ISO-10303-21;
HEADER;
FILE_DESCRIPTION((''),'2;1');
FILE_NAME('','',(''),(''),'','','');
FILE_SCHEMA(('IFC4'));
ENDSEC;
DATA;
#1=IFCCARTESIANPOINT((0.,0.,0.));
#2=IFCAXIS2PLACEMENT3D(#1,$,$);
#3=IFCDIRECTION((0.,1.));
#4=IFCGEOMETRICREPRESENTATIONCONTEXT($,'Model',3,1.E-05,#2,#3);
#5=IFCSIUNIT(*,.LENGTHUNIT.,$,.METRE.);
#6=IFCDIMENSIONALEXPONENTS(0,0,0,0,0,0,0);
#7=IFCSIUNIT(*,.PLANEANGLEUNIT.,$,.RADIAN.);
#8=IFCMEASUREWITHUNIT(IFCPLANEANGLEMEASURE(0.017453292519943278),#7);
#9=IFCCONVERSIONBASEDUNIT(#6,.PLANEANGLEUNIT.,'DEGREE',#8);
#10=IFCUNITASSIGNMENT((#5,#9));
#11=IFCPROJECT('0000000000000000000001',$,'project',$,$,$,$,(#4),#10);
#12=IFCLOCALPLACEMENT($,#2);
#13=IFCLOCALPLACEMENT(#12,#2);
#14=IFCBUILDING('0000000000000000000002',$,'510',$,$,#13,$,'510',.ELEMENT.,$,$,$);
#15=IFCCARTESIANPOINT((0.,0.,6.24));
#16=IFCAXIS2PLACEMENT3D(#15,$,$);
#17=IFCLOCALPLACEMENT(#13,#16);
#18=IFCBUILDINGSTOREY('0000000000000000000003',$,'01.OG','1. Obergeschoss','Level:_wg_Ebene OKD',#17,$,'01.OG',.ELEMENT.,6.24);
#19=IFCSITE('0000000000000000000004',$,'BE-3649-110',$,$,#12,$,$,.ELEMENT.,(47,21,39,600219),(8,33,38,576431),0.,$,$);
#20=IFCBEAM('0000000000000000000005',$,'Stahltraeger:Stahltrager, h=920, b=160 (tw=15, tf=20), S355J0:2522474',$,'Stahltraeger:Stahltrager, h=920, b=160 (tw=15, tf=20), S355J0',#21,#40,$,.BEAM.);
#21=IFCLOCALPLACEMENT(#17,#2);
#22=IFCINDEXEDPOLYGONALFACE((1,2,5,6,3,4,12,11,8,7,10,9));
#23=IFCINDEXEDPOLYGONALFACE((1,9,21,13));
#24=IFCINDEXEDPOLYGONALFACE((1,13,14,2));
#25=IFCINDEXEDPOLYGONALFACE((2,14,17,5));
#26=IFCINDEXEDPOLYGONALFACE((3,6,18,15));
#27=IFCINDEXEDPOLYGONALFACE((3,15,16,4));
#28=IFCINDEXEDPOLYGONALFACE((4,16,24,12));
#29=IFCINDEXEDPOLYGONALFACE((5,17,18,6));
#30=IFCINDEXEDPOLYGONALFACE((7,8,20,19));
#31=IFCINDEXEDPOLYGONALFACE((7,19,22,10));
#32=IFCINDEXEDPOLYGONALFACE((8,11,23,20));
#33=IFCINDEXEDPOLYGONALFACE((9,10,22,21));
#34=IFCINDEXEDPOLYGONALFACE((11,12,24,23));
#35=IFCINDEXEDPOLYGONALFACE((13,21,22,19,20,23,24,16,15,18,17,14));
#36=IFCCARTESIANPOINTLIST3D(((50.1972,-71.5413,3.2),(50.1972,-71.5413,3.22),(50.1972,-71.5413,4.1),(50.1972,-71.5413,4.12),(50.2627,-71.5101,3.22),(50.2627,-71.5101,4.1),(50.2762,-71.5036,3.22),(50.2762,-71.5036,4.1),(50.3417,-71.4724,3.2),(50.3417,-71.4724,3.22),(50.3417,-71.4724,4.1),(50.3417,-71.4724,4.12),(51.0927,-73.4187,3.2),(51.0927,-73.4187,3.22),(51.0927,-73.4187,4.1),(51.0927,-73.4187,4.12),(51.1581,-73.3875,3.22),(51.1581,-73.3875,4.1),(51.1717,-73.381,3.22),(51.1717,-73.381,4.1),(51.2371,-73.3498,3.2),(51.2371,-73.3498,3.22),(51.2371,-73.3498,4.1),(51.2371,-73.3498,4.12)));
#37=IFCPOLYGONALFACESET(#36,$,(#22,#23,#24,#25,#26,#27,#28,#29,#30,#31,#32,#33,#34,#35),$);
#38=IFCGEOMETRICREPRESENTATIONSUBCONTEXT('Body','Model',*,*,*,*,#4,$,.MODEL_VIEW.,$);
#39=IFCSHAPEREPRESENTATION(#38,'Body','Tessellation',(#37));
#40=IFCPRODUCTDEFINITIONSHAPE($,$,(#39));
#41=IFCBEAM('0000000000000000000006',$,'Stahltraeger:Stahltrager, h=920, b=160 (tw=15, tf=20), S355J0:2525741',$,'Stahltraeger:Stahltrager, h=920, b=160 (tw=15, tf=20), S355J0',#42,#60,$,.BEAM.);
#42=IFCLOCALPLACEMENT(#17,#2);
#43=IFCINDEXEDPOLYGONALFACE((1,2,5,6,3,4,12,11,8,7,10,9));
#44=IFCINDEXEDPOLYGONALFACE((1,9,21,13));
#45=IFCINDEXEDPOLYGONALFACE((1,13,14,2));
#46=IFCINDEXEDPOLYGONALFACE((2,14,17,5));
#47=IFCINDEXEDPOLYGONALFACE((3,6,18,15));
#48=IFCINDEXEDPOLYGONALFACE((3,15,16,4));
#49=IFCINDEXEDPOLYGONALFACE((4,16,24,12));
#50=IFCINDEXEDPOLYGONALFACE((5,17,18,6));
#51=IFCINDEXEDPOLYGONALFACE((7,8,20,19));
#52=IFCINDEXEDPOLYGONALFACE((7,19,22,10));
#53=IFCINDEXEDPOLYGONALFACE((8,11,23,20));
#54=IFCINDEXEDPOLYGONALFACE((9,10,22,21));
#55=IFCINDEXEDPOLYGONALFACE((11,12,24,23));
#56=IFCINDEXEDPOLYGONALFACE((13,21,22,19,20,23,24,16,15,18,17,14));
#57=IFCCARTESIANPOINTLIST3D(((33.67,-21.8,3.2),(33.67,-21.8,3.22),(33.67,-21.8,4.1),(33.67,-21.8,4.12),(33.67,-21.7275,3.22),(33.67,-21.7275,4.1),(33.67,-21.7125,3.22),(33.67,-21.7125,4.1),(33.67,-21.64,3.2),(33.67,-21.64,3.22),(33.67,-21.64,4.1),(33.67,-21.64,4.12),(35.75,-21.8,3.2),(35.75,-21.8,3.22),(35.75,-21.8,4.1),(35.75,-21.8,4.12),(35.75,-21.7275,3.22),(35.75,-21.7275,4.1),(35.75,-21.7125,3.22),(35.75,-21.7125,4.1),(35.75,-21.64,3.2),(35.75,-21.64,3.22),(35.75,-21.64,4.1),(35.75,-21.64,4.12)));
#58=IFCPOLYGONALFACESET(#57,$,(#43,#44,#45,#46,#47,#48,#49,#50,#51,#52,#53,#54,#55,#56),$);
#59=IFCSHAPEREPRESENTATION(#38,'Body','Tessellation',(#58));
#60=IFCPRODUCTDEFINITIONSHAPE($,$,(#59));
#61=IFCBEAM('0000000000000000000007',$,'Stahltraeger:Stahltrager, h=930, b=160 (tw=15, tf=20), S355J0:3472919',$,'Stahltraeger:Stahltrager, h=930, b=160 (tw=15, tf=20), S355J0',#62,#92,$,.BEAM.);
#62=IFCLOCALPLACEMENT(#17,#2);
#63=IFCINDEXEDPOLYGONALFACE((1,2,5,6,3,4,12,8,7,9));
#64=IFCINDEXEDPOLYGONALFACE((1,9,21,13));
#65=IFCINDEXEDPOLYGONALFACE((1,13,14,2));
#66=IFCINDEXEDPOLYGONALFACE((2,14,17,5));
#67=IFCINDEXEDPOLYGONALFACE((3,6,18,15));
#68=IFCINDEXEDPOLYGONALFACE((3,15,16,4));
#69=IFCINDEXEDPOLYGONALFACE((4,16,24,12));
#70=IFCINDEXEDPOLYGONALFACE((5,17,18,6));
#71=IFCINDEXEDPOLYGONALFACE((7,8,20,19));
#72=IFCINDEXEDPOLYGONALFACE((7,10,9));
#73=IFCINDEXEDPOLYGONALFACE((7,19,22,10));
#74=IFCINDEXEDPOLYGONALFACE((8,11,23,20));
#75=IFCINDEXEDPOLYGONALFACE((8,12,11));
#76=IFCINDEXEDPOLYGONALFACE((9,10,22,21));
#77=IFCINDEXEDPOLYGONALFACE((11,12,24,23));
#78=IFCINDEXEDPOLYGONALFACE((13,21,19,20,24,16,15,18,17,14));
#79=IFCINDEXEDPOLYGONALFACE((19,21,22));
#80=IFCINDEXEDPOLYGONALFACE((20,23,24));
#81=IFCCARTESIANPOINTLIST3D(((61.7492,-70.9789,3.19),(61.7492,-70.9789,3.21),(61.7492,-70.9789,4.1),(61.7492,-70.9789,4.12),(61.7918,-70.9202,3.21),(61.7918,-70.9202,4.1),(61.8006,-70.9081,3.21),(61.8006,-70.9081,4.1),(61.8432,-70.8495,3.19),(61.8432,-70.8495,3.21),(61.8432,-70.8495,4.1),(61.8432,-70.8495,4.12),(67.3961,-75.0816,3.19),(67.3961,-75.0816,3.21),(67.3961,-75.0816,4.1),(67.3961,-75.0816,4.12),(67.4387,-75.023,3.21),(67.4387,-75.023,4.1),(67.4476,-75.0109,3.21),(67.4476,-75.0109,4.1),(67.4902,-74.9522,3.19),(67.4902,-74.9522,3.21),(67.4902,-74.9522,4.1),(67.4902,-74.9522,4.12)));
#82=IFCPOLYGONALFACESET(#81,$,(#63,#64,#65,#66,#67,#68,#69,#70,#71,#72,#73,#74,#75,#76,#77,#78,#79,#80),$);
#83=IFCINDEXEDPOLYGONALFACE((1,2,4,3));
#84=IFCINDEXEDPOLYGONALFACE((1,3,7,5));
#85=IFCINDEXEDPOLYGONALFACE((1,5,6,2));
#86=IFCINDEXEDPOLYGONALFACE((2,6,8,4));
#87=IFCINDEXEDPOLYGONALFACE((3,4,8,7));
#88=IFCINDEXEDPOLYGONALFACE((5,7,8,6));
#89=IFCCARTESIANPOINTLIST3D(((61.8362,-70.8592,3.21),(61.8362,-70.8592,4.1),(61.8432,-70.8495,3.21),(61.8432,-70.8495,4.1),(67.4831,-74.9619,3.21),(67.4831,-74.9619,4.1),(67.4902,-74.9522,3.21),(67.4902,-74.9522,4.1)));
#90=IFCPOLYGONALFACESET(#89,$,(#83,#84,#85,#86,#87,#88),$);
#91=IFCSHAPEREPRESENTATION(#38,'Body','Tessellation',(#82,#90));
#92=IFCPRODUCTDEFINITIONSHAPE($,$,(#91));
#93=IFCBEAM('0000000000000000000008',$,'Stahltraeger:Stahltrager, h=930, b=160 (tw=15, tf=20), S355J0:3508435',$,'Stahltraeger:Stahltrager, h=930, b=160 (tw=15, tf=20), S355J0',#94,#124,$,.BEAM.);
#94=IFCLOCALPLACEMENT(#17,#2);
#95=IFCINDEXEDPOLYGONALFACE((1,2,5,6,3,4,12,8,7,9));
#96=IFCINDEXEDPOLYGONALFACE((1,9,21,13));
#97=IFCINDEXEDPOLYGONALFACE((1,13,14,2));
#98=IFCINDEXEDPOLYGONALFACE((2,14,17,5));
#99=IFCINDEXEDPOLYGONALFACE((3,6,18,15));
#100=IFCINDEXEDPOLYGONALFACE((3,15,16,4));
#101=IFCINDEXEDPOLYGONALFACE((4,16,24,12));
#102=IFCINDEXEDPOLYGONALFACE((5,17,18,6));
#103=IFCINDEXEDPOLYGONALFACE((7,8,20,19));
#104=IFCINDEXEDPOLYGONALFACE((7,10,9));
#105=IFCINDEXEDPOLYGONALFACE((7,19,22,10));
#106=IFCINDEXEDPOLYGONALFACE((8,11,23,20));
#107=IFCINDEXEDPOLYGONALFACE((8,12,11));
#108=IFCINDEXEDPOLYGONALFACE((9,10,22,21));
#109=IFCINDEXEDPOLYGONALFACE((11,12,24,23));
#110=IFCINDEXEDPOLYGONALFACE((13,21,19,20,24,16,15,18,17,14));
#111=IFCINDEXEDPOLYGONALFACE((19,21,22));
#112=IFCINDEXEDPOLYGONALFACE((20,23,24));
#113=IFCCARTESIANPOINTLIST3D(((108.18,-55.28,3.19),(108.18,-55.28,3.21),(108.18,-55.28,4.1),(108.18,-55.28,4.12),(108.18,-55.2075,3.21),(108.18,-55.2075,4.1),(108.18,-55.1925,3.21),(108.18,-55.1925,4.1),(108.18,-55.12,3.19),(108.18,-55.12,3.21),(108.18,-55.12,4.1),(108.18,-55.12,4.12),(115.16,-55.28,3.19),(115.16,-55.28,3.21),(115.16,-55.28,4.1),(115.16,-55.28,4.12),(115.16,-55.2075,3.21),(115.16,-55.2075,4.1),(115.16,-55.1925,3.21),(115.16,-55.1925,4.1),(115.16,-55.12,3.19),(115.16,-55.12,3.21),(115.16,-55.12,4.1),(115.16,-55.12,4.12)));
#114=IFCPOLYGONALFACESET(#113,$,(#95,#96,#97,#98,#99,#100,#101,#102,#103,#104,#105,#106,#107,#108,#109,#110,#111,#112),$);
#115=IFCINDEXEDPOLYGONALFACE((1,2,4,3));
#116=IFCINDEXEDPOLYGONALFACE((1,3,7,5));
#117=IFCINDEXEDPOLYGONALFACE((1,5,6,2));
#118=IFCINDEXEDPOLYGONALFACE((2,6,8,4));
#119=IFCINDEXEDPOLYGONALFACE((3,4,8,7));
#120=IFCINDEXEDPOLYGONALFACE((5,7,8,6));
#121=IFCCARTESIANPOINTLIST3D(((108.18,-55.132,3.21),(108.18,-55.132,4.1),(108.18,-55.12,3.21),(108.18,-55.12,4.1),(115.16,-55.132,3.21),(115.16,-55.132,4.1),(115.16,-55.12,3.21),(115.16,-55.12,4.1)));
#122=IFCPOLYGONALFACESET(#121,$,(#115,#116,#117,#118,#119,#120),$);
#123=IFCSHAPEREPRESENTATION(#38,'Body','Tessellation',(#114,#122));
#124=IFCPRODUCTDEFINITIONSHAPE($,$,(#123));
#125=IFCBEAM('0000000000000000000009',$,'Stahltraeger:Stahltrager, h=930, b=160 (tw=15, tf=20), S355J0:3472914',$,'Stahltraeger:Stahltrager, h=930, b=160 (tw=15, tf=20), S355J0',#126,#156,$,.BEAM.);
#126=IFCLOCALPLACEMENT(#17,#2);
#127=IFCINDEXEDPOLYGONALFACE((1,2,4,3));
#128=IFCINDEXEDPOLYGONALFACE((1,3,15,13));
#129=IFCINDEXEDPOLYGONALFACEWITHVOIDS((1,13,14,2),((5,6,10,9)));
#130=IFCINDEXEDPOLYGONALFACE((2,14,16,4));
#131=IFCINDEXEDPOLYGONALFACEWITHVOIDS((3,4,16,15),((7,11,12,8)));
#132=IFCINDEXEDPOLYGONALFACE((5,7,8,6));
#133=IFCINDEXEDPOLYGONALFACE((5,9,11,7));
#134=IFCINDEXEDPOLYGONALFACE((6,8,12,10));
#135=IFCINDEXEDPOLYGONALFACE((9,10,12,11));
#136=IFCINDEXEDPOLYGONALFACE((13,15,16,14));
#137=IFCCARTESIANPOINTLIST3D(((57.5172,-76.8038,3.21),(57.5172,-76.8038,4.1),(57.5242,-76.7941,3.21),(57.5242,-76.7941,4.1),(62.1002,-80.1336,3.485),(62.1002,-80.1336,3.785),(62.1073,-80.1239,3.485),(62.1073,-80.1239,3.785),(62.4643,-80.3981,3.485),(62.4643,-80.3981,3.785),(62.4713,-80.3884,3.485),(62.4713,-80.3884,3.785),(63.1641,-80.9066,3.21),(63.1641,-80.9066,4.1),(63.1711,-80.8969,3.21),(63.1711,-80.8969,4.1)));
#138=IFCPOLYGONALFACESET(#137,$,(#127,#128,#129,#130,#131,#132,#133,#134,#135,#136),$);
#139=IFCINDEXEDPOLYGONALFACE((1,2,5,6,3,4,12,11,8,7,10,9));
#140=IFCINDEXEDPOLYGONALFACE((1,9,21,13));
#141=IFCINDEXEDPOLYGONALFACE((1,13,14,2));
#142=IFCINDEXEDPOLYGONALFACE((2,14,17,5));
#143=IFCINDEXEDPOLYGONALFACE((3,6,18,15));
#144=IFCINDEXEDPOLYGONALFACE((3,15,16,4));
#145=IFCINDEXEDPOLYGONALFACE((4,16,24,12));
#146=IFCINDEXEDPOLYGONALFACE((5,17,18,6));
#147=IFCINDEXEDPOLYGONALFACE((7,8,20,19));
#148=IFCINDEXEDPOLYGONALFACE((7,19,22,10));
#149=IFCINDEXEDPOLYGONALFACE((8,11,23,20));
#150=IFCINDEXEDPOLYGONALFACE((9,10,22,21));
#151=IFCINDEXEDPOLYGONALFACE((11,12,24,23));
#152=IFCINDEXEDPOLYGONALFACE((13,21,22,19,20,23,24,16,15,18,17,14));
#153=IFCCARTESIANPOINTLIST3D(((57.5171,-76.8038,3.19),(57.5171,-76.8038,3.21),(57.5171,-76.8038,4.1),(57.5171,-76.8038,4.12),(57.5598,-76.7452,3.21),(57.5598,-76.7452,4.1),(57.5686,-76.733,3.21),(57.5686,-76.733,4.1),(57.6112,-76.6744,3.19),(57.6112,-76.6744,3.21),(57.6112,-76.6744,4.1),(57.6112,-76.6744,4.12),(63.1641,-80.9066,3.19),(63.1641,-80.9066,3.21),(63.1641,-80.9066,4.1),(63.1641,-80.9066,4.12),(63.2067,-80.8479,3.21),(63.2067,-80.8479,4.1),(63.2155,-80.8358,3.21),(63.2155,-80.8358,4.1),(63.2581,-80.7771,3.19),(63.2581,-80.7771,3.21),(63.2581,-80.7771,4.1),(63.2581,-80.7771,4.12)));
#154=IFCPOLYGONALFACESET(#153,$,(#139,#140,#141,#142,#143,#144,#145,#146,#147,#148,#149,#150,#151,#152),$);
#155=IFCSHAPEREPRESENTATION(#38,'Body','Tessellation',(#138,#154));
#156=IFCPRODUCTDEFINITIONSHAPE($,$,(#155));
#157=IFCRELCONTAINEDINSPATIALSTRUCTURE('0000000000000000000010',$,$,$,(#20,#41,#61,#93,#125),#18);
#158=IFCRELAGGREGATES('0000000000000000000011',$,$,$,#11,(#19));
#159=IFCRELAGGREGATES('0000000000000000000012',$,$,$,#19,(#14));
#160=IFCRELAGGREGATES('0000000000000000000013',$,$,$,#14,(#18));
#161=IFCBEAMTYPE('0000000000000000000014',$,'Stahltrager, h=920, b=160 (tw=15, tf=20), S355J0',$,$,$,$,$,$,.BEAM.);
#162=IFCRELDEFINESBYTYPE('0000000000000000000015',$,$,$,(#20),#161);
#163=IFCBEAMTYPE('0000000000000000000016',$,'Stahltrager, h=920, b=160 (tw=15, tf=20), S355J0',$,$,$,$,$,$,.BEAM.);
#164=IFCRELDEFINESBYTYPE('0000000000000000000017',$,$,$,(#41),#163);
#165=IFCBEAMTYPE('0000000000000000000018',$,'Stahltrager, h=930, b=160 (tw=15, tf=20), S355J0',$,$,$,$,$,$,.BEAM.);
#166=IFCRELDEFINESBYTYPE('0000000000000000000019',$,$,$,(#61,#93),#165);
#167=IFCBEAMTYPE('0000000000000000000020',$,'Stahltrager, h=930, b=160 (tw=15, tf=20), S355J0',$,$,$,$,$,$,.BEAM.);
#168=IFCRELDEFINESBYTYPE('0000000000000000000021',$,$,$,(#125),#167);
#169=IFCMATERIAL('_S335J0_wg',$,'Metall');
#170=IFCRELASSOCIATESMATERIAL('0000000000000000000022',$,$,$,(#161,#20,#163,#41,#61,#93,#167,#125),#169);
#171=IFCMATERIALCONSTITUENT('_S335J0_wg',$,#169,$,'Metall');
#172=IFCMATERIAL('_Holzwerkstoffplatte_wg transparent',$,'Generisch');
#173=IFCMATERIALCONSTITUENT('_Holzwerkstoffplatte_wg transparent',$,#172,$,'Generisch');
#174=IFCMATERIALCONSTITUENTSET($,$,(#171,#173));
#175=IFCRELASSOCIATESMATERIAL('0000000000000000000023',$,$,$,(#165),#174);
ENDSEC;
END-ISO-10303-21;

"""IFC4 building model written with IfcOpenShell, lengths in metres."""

from ifc_helpers import new_model, entity, si_unit, converted_unit, direction, frame, origin, place, context, subcontext, project, spatial, indexed_curve, outline, extrude, source, transform, mapped, material, constituent, constituent_set, type_object, type_shapes, element, save


model = new_model("IFC4")

# Units and contexts
model_context = context("Model", 3, precision=1e-05, world=origin(), true_north=direction((0.0, 1.0)))
body_context = subcontext(model_context, "Body", "Model", "MODEL_VIEW")
ifc_project = project(units=[si_unit("LENGTHUNIT", "METRE"), converted_unit("PLANEANGLEUNIT", "DEGREE", entity("IfcPlaneAngleMeasure", 0.017453292519943278), si_unit("PLANEANGLEUNIT", "RADIAN"), dimensions=[0, 0, 0, 0, 0, 0, 0])], contexts=[model_context])

# Site, building, storey
site_placement = place(None, origin())
site = spatial("IfcSite", under=ifc_project, at=site_placement, Name="BE-3649-110", CompositionType="ELEMENT", RefLatitude=(47, 21, 39, 600219), RefLongitude=(8, 33, 38, 576431), RefElevation=0.0)
building_placement = place(site_placement, origin())
building = spatial("IfcBuilding", under=site, at=building_placement, Name="510", LongName="510", CompositionType="ELEMENT")
storey_placement = place(building_placement, frame((0.0, 0.0, 6.24)))
storey = spatial("IfcBuildingStorey", under=building, at=storey_placement, Name="01.OG", Description="1. Obergeschoss", ObjectType="Level:_wg_Ebene OKD", LongName="01.OG", CompositionType="ELEMENT", Elevation=6.24)

# Beams, openings
ifc_material_1 = material(Name="_S335J0_wg", Category="Metall")
beam_type_1 = type_object("IfcBeamType", Name="Stahltrager, h=920, b=160 (tw=15, tf=20), S355J0", PredefinedType="BEAM", material=ifc_material_1)
shared_shape_1 = source(origin(), body_context, "Body", "SweptSolid", [
    extrude(outline(indexed_curve([(-0.08, -0.44), (-0.08, -0.46), (0.08, -0.46), (0.08, -0.44), (0.0075, -0.44), (0.0075, 0.44), (0.08, 0.44), (0.08, 0.46), (-0.08, 0.46), (-0.08, 0.44), (-0.0075, 0.44), (-0.0075, -0.44), (-0.08, -0.44)], self_intersect=False)), frame((0.9677, 0.0344, 0.46), z_axis=(0.430511, -0.902585, 0.0), x_axis=(0.902585, 0.430511, 0.0)), (0.0, 0.0, -1.0), 2.08),
])
type_shapes(beam_type_1, [shared_shape_1])
beam_1_placement = place(storey_placement, frame((50.1972, -73.4187, 3.2)))
beam_1 = element("IfcBeam", 1, at=beam_1_placement, inside=storey, type_object=beam_type_1, material=ifc_material_1, Name="Stahltraeger:Stahltrager, h=920, b=160 (tw=15, tf=20), S355J0:2522474", ObjectType="Stahltraeger:Stahltrager, h=920, b=160 (tw=15, tf=20), S355J0", PredefinedType="BEAM", context=body_context, shape_type="MappedRepresentation", body=[
    mapped(shared_shape_1, transform((0.0, 0.0, 0.0), scale=1.0)),
])
opening_1_placement = place(storey_placement, frame((50.1972, -73.4187, 3.2)))
element("IfcOpeningElement", 2, at=opening_1_placement, cuts=beam_1, PredefinedType="OPENING", context=body_context, shape_type="SweptSolid", body=[
    extrude(outline(indexed_curve([(-0.32, -0.22), (0.32, -0.22), (0.32, 0.22), (-0.32, 0.22), (-0.32, -0.22)], self_intersect=False)), frame((0.5148, 0.9664, -5.8217), z_axis=(0.902585, 0.430511, 0.0), x_axis=(-0.430511, 0.902585, 0.0)), (0.0, 0.0, 1.0), 0.015),
])
beam_type_2 = type_object("IfcBeamType", Name="Stahltrager, h=920, b=160 (tw=15, tf=20), S355J0", PredefinedType="BEAM", material=ifc_material_1)
shared_shape_2 = source(origin(), body_context, "Body", "SweptSolid", [
    extrude(outline(indexed_curve([(-0.08, -0.44), (-0.08, -0.46), (0.08, -0.46), (0.08, -0.44), (0.0075, -0.44), (0.0075, 0.44), (0.08, 0.44), (0.08, 0.46), (-0.08, 0.46), (-0.08, 0.44), (-0.0075, 0.44), (-0.0075, -0.44), (-0.08, -0.44)], self_intersect=False)), frame((0.0, 0.08, 0.46), z_axis=(-1.0, 0.0, 0.0), x_axis=(0.0, -1.0, 0.0)), (0.0, 0.0, -1.0), 2.08),
])
type_shapes(beam_type_2, [shared_shape_2])
beam_2_placement = place(storey_placement, frame((33.67, -21.8, 3.2)))
beam_2 = element("IfcBeam", 3, at=beam_2_placement, inside=storey, type_object=beam_type_2, material=ifc_material_1, Name="Stahltraeger:Stahltrager, h=920, b=160 (tw=15, tf=20), S355J0:2525741", ObjectType="Stahltraeger:Stahltrager, h=920, b=160 (tw=15, tf=20), S355J0", PredefinedType="BEAM", context=body_context, shape_type="MappedRepresentation", body=[
    mapped(shared_shape_2, transform((0.0, 0.0, 0.0), scale=1.0)),
])
opening_2_placement = place(storey_placement, frame((33.67, -21.8, 3.2)))
element("IfcOpeningElement", 4, at=opening_2_placement, cuts=beam_2, PredefinedType="OPENING", context=body_context, shape_type="SweptSolid", body=[
    extrude(outline(indexed_curve([(-0.32, -0.22), (0.32, -0.22), (0.32, 0.22), (-0.32, 0.22), (-0.32, -0.22)], self_intersect=False)), frame((1.3687, 0.0875, -5.8), z_axis=(0.0, -1.0, 0.0), x_axis=(1.0, 0.0, 0.0)), (0.0, 0.0, 1.0), 0.015),
])

# Beams
ifc_constituent_1 = constituent(ifc_material_1, Name="_S335J0_wg", Category="Metall")
ifc_material_2 = material(Name="_Holzwerkstoffplatte_wg transparent", Category="Generisch")
ifc_constituent_2 = constituent(ifc_material_2, Name="_Holzwerkstoffplatte_wg transparent", Category="Generisch")
ifc_constituent_set_1 = constituent_set(constituents=[ifc_constituent_1, ifc_constituent_2])
beam_type_3 = type_object("IfcBeamType", Name="Stahltrager, h=930, b=160 (tw=15, tf=20), S355J0", PredefinedType="BEAM", material=ifc_constituent_set_1)
shared_shape_3 = source(origin(), body_context, "Body", "SweptSolid", [
    extrude(outline(indexed_curve([(-0.465, -0.08), (-0.445, -0.08), (-0.445, -0.0075), (0.445, -0.0075), (0.445, -0.08), (0.465, -0.08), (0.465, 0.08), (0.445, 0.08), (0.445, 0.0075), (-0.445, 0.0075), (-0.445, 0.08), (-0.465, 0.08), (-0.465, -0.08)], self_intersect=False)), frame((-3.49, 0.0, 0.0), z_axis=(1.0, 0.0, 0.0), x_axis=(0.0, 0.0, -1.0)), (0.0, 0.0, 1.0), 6.98),
    extrude(outline(indexed_curve([(-0.445, -0.006), (0.445, -0.006), (0.445, 0.006), (-0.445, 0.006), (-0.445, -0.006)], self_intersect=False)), frame((-3.49, 0.074, 0.0), z_axis=(1.0, 0.0, 0.0), x_axis=(0.0, 0.0, -1.0)), (0.0, 0.0, 1.0), 6.98),
])
type_shapes(beam_type_3, [shared_shape_3])
beam_3_placement = place(storey_placement, frame((64.6197, -72.9655, 3.655), z_axis=(0.0, 0.0, 1.0), x_axis=(0.809017, -0.587785, 0.0)))
element("IfcBeam", 5, at=beam_3_placement, inside=storey, type_object=beam_type_3, material=ifc_material_1, Name="Stahltraeger:Stahltrager, h=930, b=160 (tw=15, tf=20), S355J0:3472919", ObjectType="Stahltraeger:Stahltrager, h=930, b=160 (tw=15, tf=20), S355J0", PredefinedType="BEAM", context=body_context, shape_type="MappedRepresentation", body=[
    mapped(shared_shape_3, transform((0.0, 0.0, 0.0), scale=1.0)),
])
beam_4_placement = place(storey_placement, frame((111.67, -55.2, 3.655)))
element("IfcBeam", 6, at=beam_4_placement, inside=storey, type_object=beam_type_3, material=ifc_material_1, Name="Stahltraeger:Stahltrager, h=930, b=160 (tw=15, tf=20), S355J0:3508435", ObjectType="Stahltraeger:Stahltrager, h=930, b=160 (tw=15, tf=20), S355J0", PredefinedType="BEAM", context=body_context, shape_type="MappedRepresentation", body=[
    mapped(shared_shape_3, transform((0.0, 0.0, 0.0), scale=1.0)),
])

# Beam, opening
beam_type_4 = type_object("IfcBeamType", Name="Stahltrager, h=930, b=160 (tw=15, tf=20), S355J0", PredefinedType="BEAM", material=ifc_material_1)
shared_shape_4 = source(origin(), body_context, "Body", "SweptSolid", [
    extrude(outline(indexed_curve([(-3.49, -0.445), (3.49, -0.445), (3.49, 0.445), (-3.49, 0.445), (-3.49, -0.445)], self_intersect=False), holes=[indexed_curve([(-2.175, 0.13), (-2.175, -0.17), (-2.625, -0.17), (-2.625, 0.13), (-2.175, 0.13)], self_intersect=False)]), frame((2.8235, 2.0514, 0.465), z_axis=(0.587785, 0.809017, 0.0), x_axis=(-0.809017, 0.587785, 0.0)), (0.0, 0.0, 1.0), 0.012),
    extrude(outline(indexed_curve([(-0.08, -0.445), (-0.08, -0.465), (0.08, -0.465), (0.08, -0.445), (0.0075, -0.445), (0.0075, 0.445), (0.08, 0.445), (0.08, 0.465), (-0.08, 0.465), (-0.08, 0.445), (-0.0075, 0.445), (-0.0075, -0.445), (-0.08, -0.445)], self_intersect=False)), frame((0.047, 4.1675, 0.465), z_axis=(-0.809017, 0.587785, 0.0), x_axis=(-0.587785, -0.809017, 0.0)), (0.0, 0.0, -1.0), 6.98),
])
type_shapes(beam_type_4, [shared_shape_4])
beam_5_placement = place(storey_placement, frame((57.5171, -80.9066, 3.19)))
beam_5 = element("IfcBeam", 7, at=beam_5_placement, inside=storey, type_object=beam_type_4, material=ifc_material_1, Name="Stahltraeger:Stahltrager, h=930, b=160 (tw=15, tf=20), S355J0:3472914", ObjectType="Stahltraeger:Stahltrager, h=930, b=160 (tw=15, tf=20), S355J0", PredefinedType="BEAM", context=body_context, shape_type="MappedRepresentation", body=[
    mapped(shared_shape_4, transform((0.0, 0.0, 0.0), scale=1.0)),
])
opening_3_placement = place(storey_placement, frame((57.5171, -80.9066, 3.19)))
element("IfcOpeningElement", 8, at=opening_3_placement, cuts=beam_5, PredefinedType="OPENING", context=body_context, shape_type="SweptSolid", body=[
    extrude(outline(indexed_curve([(-0.225, -0.15), (0.225, -0.15), (0.225, 0.15), (-0.225, 0.15), (-0.225, -0.15)], self_intersect=False)), frame((4.8165, 0.7115, -5.795), z_axis=(-0.587785, -0.809017, 0.0), x_axis=(-0.809017, 0.587785, 0.0)), (0.0, 0.0, 1.0), 0.015),
])

save(model, "model.ifc")
